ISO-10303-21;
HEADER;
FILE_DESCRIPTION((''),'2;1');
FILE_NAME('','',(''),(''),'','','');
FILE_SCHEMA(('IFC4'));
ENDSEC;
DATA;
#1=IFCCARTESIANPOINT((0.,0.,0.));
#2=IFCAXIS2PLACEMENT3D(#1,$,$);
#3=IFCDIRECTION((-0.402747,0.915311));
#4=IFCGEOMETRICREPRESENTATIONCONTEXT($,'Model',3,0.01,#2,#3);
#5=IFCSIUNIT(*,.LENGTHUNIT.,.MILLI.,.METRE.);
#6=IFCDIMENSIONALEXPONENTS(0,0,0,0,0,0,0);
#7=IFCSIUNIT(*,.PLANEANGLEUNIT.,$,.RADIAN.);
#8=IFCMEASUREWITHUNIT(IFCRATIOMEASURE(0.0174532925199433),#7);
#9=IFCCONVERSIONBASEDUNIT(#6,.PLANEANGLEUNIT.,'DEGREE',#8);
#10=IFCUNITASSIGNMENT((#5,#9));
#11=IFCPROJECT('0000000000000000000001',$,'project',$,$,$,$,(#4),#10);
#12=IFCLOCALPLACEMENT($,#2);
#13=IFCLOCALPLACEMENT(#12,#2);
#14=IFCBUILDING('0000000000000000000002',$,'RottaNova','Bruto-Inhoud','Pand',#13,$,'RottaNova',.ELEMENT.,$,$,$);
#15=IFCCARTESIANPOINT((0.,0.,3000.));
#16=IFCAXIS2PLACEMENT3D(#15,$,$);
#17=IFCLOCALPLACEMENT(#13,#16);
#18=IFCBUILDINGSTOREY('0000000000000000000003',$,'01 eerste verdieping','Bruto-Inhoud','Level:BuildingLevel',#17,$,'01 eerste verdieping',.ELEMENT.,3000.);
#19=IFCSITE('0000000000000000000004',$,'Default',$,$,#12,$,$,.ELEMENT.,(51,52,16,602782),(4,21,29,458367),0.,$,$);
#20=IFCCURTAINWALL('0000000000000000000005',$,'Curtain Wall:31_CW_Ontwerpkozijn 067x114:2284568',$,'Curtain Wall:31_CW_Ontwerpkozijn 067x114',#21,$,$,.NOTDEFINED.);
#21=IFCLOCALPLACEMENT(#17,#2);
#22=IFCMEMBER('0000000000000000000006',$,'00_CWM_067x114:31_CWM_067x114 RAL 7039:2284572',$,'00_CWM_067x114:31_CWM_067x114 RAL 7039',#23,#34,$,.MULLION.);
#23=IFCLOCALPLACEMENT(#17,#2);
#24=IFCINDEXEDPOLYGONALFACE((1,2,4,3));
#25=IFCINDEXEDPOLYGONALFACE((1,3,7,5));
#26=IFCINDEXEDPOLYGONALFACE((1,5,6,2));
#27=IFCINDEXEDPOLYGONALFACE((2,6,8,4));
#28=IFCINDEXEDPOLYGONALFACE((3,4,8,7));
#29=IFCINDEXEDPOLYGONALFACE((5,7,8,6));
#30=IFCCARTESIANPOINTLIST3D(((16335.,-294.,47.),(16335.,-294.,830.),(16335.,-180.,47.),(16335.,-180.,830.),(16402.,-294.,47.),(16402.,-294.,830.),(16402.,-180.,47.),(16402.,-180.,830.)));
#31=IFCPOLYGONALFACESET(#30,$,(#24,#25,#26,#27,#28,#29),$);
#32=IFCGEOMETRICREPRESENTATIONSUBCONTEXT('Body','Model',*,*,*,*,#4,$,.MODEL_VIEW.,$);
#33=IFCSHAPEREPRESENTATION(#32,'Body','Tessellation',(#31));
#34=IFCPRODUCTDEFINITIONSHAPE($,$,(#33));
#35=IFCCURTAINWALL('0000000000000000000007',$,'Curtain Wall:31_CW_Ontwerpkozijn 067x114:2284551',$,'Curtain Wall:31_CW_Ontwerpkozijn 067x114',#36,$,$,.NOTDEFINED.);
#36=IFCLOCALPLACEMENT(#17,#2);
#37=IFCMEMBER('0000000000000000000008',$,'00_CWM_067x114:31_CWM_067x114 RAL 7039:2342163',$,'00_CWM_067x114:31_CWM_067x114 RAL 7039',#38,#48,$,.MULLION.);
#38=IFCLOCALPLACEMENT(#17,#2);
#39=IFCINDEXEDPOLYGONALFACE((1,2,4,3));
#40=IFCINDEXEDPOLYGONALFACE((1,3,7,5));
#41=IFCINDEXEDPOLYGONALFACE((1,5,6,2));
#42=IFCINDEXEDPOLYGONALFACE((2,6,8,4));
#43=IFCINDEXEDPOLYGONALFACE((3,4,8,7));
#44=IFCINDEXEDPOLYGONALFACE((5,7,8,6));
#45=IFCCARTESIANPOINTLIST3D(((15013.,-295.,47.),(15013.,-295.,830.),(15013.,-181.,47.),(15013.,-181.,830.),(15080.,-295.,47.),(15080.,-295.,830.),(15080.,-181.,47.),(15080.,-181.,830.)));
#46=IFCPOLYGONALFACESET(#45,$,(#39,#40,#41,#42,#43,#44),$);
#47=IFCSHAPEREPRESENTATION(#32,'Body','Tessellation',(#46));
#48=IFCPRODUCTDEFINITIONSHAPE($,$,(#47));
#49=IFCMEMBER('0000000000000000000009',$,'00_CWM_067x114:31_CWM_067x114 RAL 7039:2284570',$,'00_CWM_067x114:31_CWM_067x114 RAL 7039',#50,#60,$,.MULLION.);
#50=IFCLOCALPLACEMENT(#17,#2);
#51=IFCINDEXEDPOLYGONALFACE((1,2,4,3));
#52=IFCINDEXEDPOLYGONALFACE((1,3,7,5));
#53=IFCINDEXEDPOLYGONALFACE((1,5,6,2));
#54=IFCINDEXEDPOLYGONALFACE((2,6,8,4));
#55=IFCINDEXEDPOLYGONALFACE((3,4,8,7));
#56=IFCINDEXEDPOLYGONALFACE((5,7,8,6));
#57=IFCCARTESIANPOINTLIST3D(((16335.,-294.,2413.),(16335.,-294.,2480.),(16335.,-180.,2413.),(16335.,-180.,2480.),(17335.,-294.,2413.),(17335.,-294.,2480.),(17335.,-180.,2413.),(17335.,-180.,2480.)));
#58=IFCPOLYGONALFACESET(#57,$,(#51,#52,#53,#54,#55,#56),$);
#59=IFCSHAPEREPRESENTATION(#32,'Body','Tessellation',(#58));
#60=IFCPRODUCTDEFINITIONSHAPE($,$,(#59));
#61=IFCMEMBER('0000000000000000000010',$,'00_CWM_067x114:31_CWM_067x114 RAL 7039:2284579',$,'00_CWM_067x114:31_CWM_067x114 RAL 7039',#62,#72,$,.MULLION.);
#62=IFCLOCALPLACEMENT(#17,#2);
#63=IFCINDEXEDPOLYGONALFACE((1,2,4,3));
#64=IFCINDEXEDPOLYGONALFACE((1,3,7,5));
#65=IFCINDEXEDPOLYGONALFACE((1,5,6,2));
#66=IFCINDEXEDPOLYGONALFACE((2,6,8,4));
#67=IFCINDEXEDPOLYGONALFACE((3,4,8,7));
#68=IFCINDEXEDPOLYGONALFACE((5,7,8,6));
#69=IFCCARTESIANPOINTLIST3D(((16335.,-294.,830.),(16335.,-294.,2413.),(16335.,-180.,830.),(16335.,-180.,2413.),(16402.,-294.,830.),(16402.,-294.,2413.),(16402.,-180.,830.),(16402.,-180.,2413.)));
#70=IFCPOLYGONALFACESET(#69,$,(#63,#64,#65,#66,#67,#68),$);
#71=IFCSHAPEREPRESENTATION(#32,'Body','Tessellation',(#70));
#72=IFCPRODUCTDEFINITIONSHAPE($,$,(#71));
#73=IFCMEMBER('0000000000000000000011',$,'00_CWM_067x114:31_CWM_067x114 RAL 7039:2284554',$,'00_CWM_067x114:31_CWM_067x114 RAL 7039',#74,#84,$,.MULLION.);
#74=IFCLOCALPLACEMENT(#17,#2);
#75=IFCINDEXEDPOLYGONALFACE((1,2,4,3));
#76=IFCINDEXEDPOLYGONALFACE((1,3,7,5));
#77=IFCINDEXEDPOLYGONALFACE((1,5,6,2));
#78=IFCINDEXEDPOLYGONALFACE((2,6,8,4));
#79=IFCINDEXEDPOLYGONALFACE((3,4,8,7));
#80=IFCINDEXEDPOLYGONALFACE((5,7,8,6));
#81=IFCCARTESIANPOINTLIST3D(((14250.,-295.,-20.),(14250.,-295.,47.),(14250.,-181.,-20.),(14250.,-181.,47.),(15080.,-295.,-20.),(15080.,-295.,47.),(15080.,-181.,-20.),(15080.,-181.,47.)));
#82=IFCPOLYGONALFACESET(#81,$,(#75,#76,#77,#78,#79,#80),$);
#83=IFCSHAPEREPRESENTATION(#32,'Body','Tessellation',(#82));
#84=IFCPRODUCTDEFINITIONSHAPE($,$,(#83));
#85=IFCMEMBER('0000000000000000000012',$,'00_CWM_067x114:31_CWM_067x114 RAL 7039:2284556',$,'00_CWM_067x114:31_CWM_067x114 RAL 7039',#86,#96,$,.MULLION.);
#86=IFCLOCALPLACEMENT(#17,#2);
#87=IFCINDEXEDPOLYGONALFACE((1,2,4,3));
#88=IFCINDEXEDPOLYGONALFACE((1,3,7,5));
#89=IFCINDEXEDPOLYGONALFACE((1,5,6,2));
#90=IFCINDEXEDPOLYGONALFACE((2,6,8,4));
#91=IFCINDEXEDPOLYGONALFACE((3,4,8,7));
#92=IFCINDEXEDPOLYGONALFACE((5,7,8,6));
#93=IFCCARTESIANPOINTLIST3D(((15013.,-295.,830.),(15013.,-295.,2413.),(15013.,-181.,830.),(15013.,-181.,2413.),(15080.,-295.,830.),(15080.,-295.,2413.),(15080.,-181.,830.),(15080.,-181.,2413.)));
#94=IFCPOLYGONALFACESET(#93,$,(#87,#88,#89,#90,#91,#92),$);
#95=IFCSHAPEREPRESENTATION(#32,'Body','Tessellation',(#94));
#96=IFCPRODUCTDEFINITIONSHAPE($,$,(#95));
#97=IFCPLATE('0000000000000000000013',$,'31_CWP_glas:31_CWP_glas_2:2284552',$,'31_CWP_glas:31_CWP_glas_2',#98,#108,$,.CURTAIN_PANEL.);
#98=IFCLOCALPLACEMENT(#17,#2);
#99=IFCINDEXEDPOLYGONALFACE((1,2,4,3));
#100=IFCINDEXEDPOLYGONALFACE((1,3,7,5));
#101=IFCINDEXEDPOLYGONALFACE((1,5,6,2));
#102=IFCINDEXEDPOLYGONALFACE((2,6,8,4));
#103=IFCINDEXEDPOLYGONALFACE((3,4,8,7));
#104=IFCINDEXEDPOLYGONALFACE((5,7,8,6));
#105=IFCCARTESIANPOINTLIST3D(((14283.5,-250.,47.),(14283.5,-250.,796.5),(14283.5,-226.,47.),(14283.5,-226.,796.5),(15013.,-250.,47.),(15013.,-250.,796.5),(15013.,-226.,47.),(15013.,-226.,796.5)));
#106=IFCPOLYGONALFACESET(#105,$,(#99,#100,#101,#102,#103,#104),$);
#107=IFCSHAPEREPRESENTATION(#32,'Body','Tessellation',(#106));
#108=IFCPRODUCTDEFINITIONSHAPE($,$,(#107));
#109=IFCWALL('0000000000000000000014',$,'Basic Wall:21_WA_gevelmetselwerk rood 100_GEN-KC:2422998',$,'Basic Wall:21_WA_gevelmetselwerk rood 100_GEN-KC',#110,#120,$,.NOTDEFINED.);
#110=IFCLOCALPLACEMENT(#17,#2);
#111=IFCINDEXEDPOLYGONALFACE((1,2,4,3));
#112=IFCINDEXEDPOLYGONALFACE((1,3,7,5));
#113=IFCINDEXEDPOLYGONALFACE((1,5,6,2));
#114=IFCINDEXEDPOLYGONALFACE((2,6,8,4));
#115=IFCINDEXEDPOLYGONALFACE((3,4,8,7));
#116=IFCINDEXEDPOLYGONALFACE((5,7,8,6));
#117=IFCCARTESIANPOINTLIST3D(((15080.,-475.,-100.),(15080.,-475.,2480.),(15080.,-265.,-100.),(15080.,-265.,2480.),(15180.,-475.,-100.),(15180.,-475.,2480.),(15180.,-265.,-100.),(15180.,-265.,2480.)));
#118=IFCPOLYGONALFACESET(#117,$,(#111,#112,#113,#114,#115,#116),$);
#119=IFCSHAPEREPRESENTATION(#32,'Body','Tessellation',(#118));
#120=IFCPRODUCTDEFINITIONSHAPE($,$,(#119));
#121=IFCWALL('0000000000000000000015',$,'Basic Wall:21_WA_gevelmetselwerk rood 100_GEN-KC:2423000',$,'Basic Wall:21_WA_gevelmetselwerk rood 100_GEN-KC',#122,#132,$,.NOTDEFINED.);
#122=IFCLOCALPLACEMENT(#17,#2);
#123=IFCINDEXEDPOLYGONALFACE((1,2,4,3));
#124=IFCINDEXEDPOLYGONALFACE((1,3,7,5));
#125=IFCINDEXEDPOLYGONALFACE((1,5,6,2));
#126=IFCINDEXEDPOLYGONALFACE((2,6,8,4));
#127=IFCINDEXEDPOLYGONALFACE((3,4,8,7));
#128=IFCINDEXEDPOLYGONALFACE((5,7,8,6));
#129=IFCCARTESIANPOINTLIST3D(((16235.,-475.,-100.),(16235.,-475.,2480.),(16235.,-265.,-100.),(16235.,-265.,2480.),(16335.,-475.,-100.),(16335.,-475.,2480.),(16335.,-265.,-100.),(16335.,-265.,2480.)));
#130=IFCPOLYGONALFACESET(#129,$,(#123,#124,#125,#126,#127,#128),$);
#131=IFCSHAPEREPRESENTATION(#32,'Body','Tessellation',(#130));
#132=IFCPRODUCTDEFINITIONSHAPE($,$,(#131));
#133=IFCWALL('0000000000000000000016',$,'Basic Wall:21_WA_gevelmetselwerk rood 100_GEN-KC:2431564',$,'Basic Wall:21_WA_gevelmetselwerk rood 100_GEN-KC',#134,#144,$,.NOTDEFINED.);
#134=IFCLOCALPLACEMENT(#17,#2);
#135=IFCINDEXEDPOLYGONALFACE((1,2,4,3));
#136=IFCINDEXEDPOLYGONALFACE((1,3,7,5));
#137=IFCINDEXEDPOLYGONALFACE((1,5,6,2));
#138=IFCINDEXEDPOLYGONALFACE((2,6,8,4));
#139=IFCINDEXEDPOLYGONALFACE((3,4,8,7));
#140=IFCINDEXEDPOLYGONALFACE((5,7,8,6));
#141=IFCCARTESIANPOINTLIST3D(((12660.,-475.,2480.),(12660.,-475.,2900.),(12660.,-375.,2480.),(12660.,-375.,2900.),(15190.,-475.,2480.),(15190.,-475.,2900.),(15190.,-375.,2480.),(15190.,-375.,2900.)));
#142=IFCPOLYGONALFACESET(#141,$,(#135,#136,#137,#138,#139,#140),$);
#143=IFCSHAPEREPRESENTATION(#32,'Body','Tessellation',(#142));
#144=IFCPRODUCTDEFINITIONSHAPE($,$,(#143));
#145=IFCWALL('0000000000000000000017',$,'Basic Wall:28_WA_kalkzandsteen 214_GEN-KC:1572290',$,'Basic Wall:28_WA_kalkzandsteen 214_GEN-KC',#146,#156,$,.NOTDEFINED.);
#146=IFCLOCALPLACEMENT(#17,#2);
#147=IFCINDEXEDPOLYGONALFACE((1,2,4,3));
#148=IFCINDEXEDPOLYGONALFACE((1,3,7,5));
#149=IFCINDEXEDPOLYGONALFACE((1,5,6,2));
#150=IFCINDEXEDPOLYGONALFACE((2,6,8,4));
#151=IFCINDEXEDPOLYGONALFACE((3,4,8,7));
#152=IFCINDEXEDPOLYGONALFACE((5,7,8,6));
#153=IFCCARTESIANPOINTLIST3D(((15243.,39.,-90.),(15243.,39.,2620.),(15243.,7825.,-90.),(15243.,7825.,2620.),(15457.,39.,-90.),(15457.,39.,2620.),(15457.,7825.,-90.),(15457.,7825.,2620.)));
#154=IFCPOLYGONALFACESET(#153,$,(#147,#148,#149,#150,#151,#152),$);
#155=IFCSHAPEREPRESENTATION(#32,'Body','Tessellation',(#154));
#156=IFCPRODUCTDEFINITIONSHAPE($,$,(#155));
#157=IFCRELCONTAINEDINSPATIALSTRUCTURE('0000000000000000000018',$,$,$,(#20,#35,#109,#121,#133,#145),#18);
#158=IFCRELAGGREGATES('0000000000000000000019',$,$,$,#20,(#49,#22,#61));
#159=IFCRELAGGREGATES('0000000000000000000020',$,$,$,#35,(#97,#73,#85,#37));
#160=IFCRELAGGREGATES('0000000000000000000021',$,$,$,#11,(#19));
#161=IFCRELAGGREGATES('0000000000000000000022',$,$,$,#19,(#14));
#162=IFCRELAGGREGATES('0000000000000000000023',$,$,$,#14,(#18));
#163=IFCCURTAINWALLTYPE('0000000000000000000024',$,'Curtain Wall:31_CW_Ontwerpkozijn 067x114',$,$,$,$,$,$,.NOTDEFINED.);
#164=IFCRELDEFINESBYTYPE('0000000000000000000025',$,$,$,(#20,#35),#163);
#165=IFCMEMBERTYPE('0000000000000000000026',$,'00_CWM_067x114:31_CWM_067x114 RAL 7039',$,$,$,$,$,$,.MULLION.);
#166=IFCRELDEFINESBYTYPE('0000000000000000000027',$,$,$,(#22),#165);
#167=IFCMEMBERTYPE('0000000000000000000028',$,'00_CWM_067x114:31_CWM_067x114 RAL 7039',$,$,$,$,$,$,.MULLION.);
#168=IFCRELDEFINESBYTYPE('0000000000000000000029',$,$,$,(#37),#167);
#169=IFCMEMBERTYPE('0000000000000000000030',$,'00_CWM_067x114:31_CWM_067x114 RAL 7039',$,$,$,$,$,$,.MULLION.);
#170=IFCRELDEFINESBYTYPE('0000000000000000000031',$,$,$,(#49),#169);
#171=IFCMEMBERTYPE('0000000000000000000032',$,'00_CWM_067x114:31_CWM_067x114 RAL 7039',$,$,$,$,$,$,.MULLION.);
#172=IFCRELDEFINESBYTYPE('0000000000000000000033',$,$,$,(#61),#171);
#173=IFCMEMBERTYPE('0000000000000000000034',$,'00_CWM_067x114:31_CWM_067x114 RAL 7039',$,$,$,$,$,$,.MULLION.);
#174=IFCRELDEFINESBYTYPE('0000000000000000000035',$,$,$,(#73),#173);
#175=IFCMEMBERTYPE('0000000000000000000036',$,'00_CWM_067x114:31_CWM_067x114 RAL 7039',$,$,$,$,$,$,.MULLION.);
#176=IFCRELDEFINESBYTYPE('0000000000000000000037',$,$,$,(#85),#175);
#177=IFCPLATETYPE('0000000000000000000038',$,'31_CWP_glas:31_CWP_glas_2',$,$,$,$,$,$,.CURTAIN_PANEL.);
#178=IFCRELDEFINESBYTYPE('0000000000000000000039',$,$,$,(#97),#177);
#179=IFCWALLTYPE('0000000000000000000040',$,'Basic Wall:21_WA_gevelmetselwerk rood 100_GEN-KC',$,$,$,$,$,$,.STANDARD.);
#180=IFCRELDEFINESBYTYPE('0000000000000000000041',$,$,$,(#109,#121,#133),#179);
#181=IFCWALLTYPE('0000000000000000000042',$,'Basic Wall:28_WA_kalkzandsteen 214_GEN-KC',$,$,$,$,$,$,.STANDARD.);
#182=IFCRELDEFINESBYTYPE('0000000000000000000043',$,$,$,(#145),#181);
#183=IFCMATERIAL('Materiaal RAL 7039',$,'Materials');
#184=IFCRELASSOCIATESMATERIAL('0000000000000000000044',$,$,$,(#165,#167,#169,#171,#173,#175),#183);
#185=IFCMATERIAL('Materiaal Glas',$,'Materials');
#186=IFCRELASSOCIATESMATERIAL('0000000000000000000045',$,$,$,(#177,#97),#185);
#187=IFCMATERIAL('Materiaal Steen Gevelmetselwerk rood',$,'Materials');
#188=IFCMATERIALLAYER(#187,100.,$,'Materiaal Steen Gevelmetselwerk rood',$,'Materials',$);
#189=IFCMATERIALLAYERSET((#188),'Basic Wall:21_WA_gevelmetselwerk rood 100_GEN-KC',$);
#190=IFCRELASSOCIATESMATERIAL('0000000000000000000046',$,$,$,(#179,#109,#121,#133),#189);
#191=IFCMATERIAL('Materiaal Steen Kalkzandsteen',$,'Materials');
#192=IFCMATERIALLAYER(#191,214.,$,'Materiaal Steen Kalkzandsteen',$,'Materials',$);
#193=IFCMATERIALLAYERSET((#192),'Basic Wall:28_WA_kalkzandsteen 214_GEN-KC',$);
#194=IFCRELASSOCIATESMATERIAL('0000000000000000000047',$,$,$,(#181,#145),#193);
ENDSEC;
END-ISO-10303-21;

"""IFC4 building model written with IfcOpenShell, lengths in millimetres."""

from ifc_helpers import new_model, entity, si_unit, converted_unit, direction, frame, frame_2d, origin, origin_2d_with_axis, place, context, subcontext, project, spatial, rectangle, extrude, source, transform, mapped, material, layer, layer_set, material_profile, profile_set, type_object, type_shapes, element, aggregate, save


model = new_model("IFC4")

# Units and contexts
model_context = context("Model", 3, precision=0.01, world=origin(), true_north=direction((-0.402747, 0.915311)))
body_context = subcontext(model_context, "Body", "Model", "MODEL_VIEW")
ifc_project = project(units=[si_unit("LENGTHUNIT", "METRE", prefix="MILLI"), converted_unit("PLANEANGLEUNIT", "DEGREE", entity("IfcRatioMeasure", 0.0174532925199433), si_unit("PLANEANGLEUNIT", "RADIAN"), dimensions=[0, 0, 0, 0, 0, 0, 0])], contexts=[model_context])

# Site, building, storey
site_placement = place(None, origin())
site = spatial("IfcSite", under=ifc_project, at=site_placement, Name="Default", CompositionType="ELEMENT", RefLatitude=(51, 52, 16, 602782), RefLongitude=(4, 21, 29, 458367), RefElevation=0.0)
building_placement = place(site_placement, origin())
building = spatial("IfcBuilding", under=site, at=building_placement, Name="RottaNova", Description="Bruto-Inhoud", ObjectType="Pand", LongName="RottaNova", CompositionType="ELEMENT")
storey_placement = place(building_placement, frame((0.0, 0.0, 3000.0)))
storey = spatial("IfcBuildingStorey", under=building, at=storey_placement, Name="01 eerste verdieping", Description="Bruto-Inhoud", ObjectType="Level:BuildingLevel", LongName="01 eerste verdieping", CompositionType="ELEMENT", Elevation=3000.0)

# Curtain walls, members
curtain_wall_type = type_object("IfcCurtainWallType", Name="Curtain Wall:31_CW_Ontwerpkozijn 067x114", PredefinedType="NOTDEFINED")
curtain_wall_1_placement = place(storey_placement, frame((0.0, 0.0, -3000.0)))
curtain_wall_1 = element("IfcCurtainWall", 1, at=curtain_wall_1_placement, inside=storey, type_object=curtain_wall_type, Name="Curtain Wall:31_CW_Ontwerpkozijn 067x114:2284568", ObjectType="Curtain Wall:31_CW_Ontwerpkozijn 067x114", PredefinedType="NOTDEFINED")
ifc_material_1 = material(Name="Materiaal RAL 7039", Category="Materials")
ifc_material_profile = material_profile(ifc_material_1, rectangle(XDim=114.0, YDim=67.0, at=origin_2d_with_axis()), Name="31_CWM_067x114 RAL 7039")
ifc_profile_set = profile_set([ifc_material_profile], Name="31_CWM_067x114 RAL 7039")
member_type_1 = type_object("IfcMemberType", Name="00_CWM_067x114:31_CWM_067x114 RAL 7039", PredefinedType="MULLION", material=ifc_profile_set)
shared_shape_1 = source(origin(), body_context, "Body", "SweptSolid", [
    extrude(rectangle(XDim=114.0, YDim=67.0, at=frame_2d((0.0, 0.0), x_axis=(1.0, 0.0))), frame((-33.5, -57.0, -783.0), z_axis=(0.0, 0.0, 1.0), x_axis=(0.0, -1.0, 0.0)), (0.0, 0.0, 1.0), 783.0),
])
type_shapes(member_type_1, [shared_shape_1])
member_1_placement = place(curtain_wall_1_placement, frame((16335.0, -180.0, 3047.0), z_axis=(0.0, 0.0, -1.0), x_axis=(-1.0, 0.0, 0.0)))
member_1 = element("IfcMember", 2, at=member_1_placement, type_object=member_type_1, Name="00_CWM_067x114:31_CWM_067x114 RAL 7039:2284572", ObjectType="00_CWM_067x114:31_CWM_067x114 RAL 7039", PredefinedType="MULLION", context=body_context, shape_type="MappedRepresentation", body=[
    mapped(shared_shape_1, transform((0.0, 0.0, 0.0), scale=1.0)),
])
curtain_wall_2_placement = place(storey_placement, frame((0.0, 0.0, -3000.0)))
curtain_wall_2 = element("IfcCurtainWall", 3, at=curtain_wall_2_placement, inside=storey, type_object=curtain_wall_type, Name="Curtain Wall:31_CW_Ontwerpkozijn 067x114:2284551", ObjectType="Curtain Wall:31_CW_Ontwerpkozijn 067x114", PredefinedType="NOTDEFINED")
member_type_2 = type_object("IfcMemberType", Name="00_CWM_067x114:31_CWM_067x114 RAL 7039", PredefinedType="MULLION", material=ifc_profile_set)
shared_shape_2 = source(origin(), body_context, "Body", "SweptSolid", [
    extrude(rectangle(XDim=114.0, YDim=67.0, at=frame_2d((0.0, 0.0), x_axis=(1.0, 0.0))), frame((-33.5, -57.0, -783.0), z_axis=(0.0, 0.0, 1.0), x_axis=(0.0, -1.0, 0.0)), (0.0, 0.0, 1.0), 783.0),
])
type_shapes(member_type_2, [shared_shape_2])
member_2_placement = place(curtain_wall_2_placement, frame((15080.0, -181.0, 3830.0)))
member_2 = element("IfcMember", 4, at=member_2_placement, type_object=member_type_2, Name="00_CWM_067x114:31_CWM_067x114 RAL 7039:2342163", ObjectType="00_CWM_067x114:31_CWM_067x114 RAL 7039", PredefinedType="MULLION", context=body_context, shape_type="MappedRepresentation", body=[
    mapped(shared_shape_2, transform((0.0, 0.0, 0.0), scale=1.0)),
])

# Members
member_type_3 = type_object("IfcMemberType", Name="00_CWM_067x114:31_CWM_067x114 RAL 7039", PredefinedType="MULLION", material=ifc_profile_set)
shared_shape_3 = source(origin(), body_context, "Body", "SweptSolid", [
    extrude(rectangle(XDim=114.0, YDim=67.0, at=frame_2d((0.0, 0.0), x_axis=(1.0, 0.0))), frame((-33.5, -57.0, -1000.0), z_axis=(0.0, 0.0, 1.0), x_axis=(0.0, -1.0, 0.0)), (0.0, 0.0, 1.0), 1000.0),
])
type_shapes(member_type_3, [shared_shape_3])
member_3_placement = place(curtain_wall_1_placement, frame((16335.0, -180.0, 5480.0), z_axis=(-1.0, 0.0, 0.0), x_axis=(0.0, 0.0, 1.0)))
member_3 = element("IfcMember", 5, at=member_3_placement, type_object=member_type_3, Name="00_CWM_067x114:31_CWM_067x114 RAL 7039:2284570", ObjectType="00_CWM_067x114:31_CWM_067x114 RAL 7039", PredefinedType="MULLION", context=body_context, shape_type="MappedRepresentation", body=[
    mapped(shared_shape_3, transform((0.0, 0.0, 0.0), scale=1.0)),
])
member_type_4 = type_object("IfcMemberType", Name="00_CWM_067x114:31_CWM_067x114 RAL 7039", PredefinedType="MULLION", material=ifc_profile_set)
shared_shape_4 = source(origin(), body_context, "Body", "SweptSolid", [
    extrude(rectangle(XDim=114.0, YDim=67.0, at=frame_2d((0.0, 0.0), x_axis=(1.0, 0.0))), frame((-33.5, -57.0, -1583.0), z_axis=(0.0, 0.0, 1.0), x_axis=(0.0, -1.0, 0.0)), (0.0, 0.0, 1.0), 1583.0),
])
type_shapes(member_type_4, [shared_shape_4])
member_4_placement = place(curtain_wall_1_placement, frame((16335.0, -180.0, 3830.0), z_axis=(0.0, 0.0, -1.0), x_axis=(-1.0, 0.0, 0.0)))
member_4 = element("IfcMember", 6, at=member_4_placement, type_object=member_type_4, Name="00_CWM_067x114:31_CWM_067x114 RAL 7039:2284579", ObjectType="00_CWM_067x114:31_CWM_067x114 RAL 7039", PredefinedType="MULLION", context=body_context, shape_type="MappedRepresentation", body=[
    mapped(shared_shape_4, transform((0.0, 0.0, 0.0), scale=1.0)),
])
aggregate(curtain_wall_1, [member_3, member_1, member_4])
member_type_5 = type_object("IfcMemberType", Name="00_CWM_067x114:31_CWM_067x114 RAL 7039", PredefinedType="MULLION", material=ifc_profile_set)
shared_shape_5 = source(origin(), body_context, "Body", "SweptSolid", [
    extrude(rectangle(XDim=114.0, YDim=67.0, at=frame_2d((0.0, 0.0), x_axis=(1.0, 0.0))), frame((-33.5, -57.0, -830.0), z_axis=(0.0, 0.0, 1.0), x_axis=(0.0, -1.0, 0.0)), (0.0, 0.0, 1.0), 830.0),
])
type_shapes(member_type_5, [shared_shape_5])
member_5_placement = place(curtain_wall_2_placement, frame((15080.0, -181.0, 2980.0), z_axis=(1.0, 0.0, 0.0), x_axis=(0.0, 0.0, -1.0)))
member_5 = element("IfcMember", 7, at=member_5_placement, type_object=member_type_5, Name="00_CWM_067x114:31_CWM_067x114 RAL 7039:2284554", ObjectType="00_CWM_067x114:31_CWM_067x114 RAL 7039", PredefinedType="MULLION", context=body_context, shape_type="MappedRepresentation", body=[
    mapped(shared_shape_5, transform((0.0, 0.0, 0.0), scale=1.0)),
])
member_type_6 = type_object("IfcMemberType", Name="00_CWM_067x114:31_CWM_067x114 RAL 7039", PredefinedType="MULLION", material=ifc_profile_set)
shared_shape_6 = source(origin(), body_context, "Body", "SweptSolid", [
    extrude(rectangle(XDim=114.0, YDim=67.0, at=origin_2d_with_axis()), frame((-33.5, -57.0, -1583.0), z_axis=(0.0, 0.0, 1.0), x_axis=(0.0, -1.0, 0.0)), (0.0, 0.0, 1.0), 1583.0),
])
type_shapes(member_type_6, [shared_shape_6])
member_6_placement = place(curtain_wall_2_placement, frame((15080.0, -181.0, 5413.0)))
member_6 = element("IfcMember", 8, at=member_6_placement, type_object=member_type_6, Name="00_CWM_067x114:31_CWM_067x114 RAL 7039:2284556", ObjectType="00_CWM_067x114:31_CWM_067x114 RAL 7039", PredefinedType="MULLION", context=body_context, shape_type="MappedRepresentation", body=[
    mapped(shared_shape_6, transform((0.0, 0.0, 0.0), scale=1.0)),
])

# Plate
ifc_material_2 = material(Name="Materiaal Glas", Category="Materials")
plate_type = type_object("IfcPlateType", Name="31_CWP_glas:31_CWP_glas_2", PredefinedType="CURTAIN_PANEL", material=ifc_material_2)
shared_shape_7 = source(origin(), body_context, "Body", "SweptSolid", [
    extrude(rectangle(XDim=24.0, YDim=729.5, at=frame_2d((0.0, 0.0), x_axis=(1.0, 0.0))), frame((364.8, 12.0, 0.0), z_axis=(0.0, 0.0, 1.0), x_axis=(0.0, 1.0, 0.0)), (0.0, 0.0, 1.0), 749.5),
])
type_shapes(plate_type, [shared_shape_7])
plate_placement = place(curtain_wall_2_placement, frame((15013.0, -226.0, 3047.0), z_axis=(0.0, 0.0, 1.0), x_axis=(-1.0, 0.0, 0.0)))
plate = element("IfcPlate", 9, at=plate_placement, type_object=plate_type, material=ifc_material_2, Name="31_CWP_glas:31_CWP_glas_2:2284552", ObjectType="31_CWP_glas:31_CWP_glas_2", PredefinedType="CURTAIN_PANEL", context=body_context, shape_type="MappedRepresentation", body=[
    mapped(shared_shape_7, transform((0.0, 0.0, 0.0), scale=1.0)),
])

# Walls
ifc_material_3 = material(Name="Materiaal Steen Gevelmetselwerk rood", Category="Materials")
ifc_layer_1 = layer(ifc_material_3, 100.0, Name="Materiaal Steen Gevelmetselwerk rood", Category="Materials")
ifc_layer_set_1 = layer_set([ifc_layer_1], Name="Basic Wall:21_WA_gevelmetselwerk rood 100_GEN-KC")
wall_type_1 = type_object("IfcWallType", Name="Basic Wall:21_WA_gevelmetselwerk rood 100_GEN-KC", PredefinedType="STANDARD", material=ifc_layer_set_1)
wall_1_placement = place(storey_placement, frame((15130.0, -265.0, -100.0), z_axis=(0.0, 0.0, 1.0), x_axis=(0.0, -1.0, 0.0)))
element("IfcWall", 10, at=wall_1_placement, inside=storey, type_object=wall_type_1, material=ifc_layer_set_1, Name="Basic Wall:21_WA_gevelmetselwerk rood 100_GEN-KC:2422998", ObjectType="Basic Wall:21_WA_gevelmetselwerk rood 100_GEN-KC", PredefinedType="NOTDEFINED", context=body_context, shape_type="SweptSolid", body=[
    extrude(rectangle(XDim=210.0, YDim=100.0, at=frame_2d((105.0, 0.0), x_axis=(-1.0, 0.0))), origin(), (0.0, 0.0, 1.0), 2580.0),
])
wall_2_placement = place(storey_placement, frame((16285.0, -265.0, -100.0), z_axis=(0.0, 0.0, 1.0), x_axis=(0.0, -1.0, 0.0)))
element("IfcWall", 11, at=wall_2_placement, inside=storey, type_object=wall_type_1, material=ifc_layer_set_1, Name="Basic Wall:21_WA_gevelmetselwerk rood 100_GEN-KC:2423000", ObjectType="Basic Wall:21_WA_gevelmetselwerk rood 100_GEN-KC", PredefinedType="NOTDEFINED", context=body_context, shape_type="SweptSolid", body=[
    extrude(rectangle(XDim=210.0, YDim=100.0, at=frame_2d((105.0, 0.0), x_axis=(-1.0, 0.0))), origin(), (0.0, 0.0, 1.0), 2580.0),
])

# Walls
wall_3_placement = place(storey_placement, frame((15190.0, -425.0, 2480.0), z_axis=(0.0, 0.0, 1.0), x_axis=(-1.0, 0.0, 0.0)))
element("IfcWall", 12, at=wall_3_placement, inside=storey, type_object=wall_type_1, material=ifc_layer_set_1, Name="Basic Wall:21_WA_gevelmetselwerk rood 100_GEN-KC:2431564", ObjectType="Basic Wall:21_WA_gevelmetselwerk rood 100_GEN-KC", PredefinedType="NOTDEFINED", context=body_context, shape_type="SweptSolid", body=[
    extrude(rectangle(XDim=2530.0, YDim=100.0, at=frame_2d((1265.0, 0.0), x_axis=(-1.0, 0.0))), origin(), (0.0, 0.0, 1.0), 420.0),
])
ifc_material_4 = material(Name="Materiaal Steen Kalkzandsteen", Category="Materials")
ifc_layer_2 = layer(ifc_material_4, 214.0, Name="Materiaal Steen Kalkzandsteen", Category="Materials")
ifc_layer_set_2 = layer_set([ifc_layer_2], Name="Basic Wall:28_WA_kalkzandsteen 214_GEN-KC")
wall_type_2 = type_object("IfcWallType", Name="Basic Wall:28_WA_kalkzandsteen 214_GEN-KC", PredefinedType="STANDARD", material=ifc_layer_set_2)
wall_4_placement = place(storey_placement, frame((15350.0, 39.0, -90.0), z_axis=(0.0, 0.0, 1.0), x_axis=(0.0, 1.0, 0.0)))
element("IfcWall", 13, at=wall_4_placement, inside=storey, type_object=wall_type_2, material=ifc_layer_set_2, Name="Basic Wall:28_WA_kalkzandsteen 214_GEN-KC:1572290", ObjectType="Basic Wall:28_WA_kalkzandsteen 214_GEN-KC", PredefinedType="NOTDEFINED", context=body_context, shape_type="SweptSolid", body=[
    extrude(rectangle(XDim=7786.0, YDim=214.0, at=origin_2d_with_axis()), frame((3893.0, 0.0, 0.0)), (0.0, 0.0, 1.0), 2710.0),
])

aggregate(curtain_wall_2, [plate, member_5, member_6, member_2])

save(model, "model.ifc")
